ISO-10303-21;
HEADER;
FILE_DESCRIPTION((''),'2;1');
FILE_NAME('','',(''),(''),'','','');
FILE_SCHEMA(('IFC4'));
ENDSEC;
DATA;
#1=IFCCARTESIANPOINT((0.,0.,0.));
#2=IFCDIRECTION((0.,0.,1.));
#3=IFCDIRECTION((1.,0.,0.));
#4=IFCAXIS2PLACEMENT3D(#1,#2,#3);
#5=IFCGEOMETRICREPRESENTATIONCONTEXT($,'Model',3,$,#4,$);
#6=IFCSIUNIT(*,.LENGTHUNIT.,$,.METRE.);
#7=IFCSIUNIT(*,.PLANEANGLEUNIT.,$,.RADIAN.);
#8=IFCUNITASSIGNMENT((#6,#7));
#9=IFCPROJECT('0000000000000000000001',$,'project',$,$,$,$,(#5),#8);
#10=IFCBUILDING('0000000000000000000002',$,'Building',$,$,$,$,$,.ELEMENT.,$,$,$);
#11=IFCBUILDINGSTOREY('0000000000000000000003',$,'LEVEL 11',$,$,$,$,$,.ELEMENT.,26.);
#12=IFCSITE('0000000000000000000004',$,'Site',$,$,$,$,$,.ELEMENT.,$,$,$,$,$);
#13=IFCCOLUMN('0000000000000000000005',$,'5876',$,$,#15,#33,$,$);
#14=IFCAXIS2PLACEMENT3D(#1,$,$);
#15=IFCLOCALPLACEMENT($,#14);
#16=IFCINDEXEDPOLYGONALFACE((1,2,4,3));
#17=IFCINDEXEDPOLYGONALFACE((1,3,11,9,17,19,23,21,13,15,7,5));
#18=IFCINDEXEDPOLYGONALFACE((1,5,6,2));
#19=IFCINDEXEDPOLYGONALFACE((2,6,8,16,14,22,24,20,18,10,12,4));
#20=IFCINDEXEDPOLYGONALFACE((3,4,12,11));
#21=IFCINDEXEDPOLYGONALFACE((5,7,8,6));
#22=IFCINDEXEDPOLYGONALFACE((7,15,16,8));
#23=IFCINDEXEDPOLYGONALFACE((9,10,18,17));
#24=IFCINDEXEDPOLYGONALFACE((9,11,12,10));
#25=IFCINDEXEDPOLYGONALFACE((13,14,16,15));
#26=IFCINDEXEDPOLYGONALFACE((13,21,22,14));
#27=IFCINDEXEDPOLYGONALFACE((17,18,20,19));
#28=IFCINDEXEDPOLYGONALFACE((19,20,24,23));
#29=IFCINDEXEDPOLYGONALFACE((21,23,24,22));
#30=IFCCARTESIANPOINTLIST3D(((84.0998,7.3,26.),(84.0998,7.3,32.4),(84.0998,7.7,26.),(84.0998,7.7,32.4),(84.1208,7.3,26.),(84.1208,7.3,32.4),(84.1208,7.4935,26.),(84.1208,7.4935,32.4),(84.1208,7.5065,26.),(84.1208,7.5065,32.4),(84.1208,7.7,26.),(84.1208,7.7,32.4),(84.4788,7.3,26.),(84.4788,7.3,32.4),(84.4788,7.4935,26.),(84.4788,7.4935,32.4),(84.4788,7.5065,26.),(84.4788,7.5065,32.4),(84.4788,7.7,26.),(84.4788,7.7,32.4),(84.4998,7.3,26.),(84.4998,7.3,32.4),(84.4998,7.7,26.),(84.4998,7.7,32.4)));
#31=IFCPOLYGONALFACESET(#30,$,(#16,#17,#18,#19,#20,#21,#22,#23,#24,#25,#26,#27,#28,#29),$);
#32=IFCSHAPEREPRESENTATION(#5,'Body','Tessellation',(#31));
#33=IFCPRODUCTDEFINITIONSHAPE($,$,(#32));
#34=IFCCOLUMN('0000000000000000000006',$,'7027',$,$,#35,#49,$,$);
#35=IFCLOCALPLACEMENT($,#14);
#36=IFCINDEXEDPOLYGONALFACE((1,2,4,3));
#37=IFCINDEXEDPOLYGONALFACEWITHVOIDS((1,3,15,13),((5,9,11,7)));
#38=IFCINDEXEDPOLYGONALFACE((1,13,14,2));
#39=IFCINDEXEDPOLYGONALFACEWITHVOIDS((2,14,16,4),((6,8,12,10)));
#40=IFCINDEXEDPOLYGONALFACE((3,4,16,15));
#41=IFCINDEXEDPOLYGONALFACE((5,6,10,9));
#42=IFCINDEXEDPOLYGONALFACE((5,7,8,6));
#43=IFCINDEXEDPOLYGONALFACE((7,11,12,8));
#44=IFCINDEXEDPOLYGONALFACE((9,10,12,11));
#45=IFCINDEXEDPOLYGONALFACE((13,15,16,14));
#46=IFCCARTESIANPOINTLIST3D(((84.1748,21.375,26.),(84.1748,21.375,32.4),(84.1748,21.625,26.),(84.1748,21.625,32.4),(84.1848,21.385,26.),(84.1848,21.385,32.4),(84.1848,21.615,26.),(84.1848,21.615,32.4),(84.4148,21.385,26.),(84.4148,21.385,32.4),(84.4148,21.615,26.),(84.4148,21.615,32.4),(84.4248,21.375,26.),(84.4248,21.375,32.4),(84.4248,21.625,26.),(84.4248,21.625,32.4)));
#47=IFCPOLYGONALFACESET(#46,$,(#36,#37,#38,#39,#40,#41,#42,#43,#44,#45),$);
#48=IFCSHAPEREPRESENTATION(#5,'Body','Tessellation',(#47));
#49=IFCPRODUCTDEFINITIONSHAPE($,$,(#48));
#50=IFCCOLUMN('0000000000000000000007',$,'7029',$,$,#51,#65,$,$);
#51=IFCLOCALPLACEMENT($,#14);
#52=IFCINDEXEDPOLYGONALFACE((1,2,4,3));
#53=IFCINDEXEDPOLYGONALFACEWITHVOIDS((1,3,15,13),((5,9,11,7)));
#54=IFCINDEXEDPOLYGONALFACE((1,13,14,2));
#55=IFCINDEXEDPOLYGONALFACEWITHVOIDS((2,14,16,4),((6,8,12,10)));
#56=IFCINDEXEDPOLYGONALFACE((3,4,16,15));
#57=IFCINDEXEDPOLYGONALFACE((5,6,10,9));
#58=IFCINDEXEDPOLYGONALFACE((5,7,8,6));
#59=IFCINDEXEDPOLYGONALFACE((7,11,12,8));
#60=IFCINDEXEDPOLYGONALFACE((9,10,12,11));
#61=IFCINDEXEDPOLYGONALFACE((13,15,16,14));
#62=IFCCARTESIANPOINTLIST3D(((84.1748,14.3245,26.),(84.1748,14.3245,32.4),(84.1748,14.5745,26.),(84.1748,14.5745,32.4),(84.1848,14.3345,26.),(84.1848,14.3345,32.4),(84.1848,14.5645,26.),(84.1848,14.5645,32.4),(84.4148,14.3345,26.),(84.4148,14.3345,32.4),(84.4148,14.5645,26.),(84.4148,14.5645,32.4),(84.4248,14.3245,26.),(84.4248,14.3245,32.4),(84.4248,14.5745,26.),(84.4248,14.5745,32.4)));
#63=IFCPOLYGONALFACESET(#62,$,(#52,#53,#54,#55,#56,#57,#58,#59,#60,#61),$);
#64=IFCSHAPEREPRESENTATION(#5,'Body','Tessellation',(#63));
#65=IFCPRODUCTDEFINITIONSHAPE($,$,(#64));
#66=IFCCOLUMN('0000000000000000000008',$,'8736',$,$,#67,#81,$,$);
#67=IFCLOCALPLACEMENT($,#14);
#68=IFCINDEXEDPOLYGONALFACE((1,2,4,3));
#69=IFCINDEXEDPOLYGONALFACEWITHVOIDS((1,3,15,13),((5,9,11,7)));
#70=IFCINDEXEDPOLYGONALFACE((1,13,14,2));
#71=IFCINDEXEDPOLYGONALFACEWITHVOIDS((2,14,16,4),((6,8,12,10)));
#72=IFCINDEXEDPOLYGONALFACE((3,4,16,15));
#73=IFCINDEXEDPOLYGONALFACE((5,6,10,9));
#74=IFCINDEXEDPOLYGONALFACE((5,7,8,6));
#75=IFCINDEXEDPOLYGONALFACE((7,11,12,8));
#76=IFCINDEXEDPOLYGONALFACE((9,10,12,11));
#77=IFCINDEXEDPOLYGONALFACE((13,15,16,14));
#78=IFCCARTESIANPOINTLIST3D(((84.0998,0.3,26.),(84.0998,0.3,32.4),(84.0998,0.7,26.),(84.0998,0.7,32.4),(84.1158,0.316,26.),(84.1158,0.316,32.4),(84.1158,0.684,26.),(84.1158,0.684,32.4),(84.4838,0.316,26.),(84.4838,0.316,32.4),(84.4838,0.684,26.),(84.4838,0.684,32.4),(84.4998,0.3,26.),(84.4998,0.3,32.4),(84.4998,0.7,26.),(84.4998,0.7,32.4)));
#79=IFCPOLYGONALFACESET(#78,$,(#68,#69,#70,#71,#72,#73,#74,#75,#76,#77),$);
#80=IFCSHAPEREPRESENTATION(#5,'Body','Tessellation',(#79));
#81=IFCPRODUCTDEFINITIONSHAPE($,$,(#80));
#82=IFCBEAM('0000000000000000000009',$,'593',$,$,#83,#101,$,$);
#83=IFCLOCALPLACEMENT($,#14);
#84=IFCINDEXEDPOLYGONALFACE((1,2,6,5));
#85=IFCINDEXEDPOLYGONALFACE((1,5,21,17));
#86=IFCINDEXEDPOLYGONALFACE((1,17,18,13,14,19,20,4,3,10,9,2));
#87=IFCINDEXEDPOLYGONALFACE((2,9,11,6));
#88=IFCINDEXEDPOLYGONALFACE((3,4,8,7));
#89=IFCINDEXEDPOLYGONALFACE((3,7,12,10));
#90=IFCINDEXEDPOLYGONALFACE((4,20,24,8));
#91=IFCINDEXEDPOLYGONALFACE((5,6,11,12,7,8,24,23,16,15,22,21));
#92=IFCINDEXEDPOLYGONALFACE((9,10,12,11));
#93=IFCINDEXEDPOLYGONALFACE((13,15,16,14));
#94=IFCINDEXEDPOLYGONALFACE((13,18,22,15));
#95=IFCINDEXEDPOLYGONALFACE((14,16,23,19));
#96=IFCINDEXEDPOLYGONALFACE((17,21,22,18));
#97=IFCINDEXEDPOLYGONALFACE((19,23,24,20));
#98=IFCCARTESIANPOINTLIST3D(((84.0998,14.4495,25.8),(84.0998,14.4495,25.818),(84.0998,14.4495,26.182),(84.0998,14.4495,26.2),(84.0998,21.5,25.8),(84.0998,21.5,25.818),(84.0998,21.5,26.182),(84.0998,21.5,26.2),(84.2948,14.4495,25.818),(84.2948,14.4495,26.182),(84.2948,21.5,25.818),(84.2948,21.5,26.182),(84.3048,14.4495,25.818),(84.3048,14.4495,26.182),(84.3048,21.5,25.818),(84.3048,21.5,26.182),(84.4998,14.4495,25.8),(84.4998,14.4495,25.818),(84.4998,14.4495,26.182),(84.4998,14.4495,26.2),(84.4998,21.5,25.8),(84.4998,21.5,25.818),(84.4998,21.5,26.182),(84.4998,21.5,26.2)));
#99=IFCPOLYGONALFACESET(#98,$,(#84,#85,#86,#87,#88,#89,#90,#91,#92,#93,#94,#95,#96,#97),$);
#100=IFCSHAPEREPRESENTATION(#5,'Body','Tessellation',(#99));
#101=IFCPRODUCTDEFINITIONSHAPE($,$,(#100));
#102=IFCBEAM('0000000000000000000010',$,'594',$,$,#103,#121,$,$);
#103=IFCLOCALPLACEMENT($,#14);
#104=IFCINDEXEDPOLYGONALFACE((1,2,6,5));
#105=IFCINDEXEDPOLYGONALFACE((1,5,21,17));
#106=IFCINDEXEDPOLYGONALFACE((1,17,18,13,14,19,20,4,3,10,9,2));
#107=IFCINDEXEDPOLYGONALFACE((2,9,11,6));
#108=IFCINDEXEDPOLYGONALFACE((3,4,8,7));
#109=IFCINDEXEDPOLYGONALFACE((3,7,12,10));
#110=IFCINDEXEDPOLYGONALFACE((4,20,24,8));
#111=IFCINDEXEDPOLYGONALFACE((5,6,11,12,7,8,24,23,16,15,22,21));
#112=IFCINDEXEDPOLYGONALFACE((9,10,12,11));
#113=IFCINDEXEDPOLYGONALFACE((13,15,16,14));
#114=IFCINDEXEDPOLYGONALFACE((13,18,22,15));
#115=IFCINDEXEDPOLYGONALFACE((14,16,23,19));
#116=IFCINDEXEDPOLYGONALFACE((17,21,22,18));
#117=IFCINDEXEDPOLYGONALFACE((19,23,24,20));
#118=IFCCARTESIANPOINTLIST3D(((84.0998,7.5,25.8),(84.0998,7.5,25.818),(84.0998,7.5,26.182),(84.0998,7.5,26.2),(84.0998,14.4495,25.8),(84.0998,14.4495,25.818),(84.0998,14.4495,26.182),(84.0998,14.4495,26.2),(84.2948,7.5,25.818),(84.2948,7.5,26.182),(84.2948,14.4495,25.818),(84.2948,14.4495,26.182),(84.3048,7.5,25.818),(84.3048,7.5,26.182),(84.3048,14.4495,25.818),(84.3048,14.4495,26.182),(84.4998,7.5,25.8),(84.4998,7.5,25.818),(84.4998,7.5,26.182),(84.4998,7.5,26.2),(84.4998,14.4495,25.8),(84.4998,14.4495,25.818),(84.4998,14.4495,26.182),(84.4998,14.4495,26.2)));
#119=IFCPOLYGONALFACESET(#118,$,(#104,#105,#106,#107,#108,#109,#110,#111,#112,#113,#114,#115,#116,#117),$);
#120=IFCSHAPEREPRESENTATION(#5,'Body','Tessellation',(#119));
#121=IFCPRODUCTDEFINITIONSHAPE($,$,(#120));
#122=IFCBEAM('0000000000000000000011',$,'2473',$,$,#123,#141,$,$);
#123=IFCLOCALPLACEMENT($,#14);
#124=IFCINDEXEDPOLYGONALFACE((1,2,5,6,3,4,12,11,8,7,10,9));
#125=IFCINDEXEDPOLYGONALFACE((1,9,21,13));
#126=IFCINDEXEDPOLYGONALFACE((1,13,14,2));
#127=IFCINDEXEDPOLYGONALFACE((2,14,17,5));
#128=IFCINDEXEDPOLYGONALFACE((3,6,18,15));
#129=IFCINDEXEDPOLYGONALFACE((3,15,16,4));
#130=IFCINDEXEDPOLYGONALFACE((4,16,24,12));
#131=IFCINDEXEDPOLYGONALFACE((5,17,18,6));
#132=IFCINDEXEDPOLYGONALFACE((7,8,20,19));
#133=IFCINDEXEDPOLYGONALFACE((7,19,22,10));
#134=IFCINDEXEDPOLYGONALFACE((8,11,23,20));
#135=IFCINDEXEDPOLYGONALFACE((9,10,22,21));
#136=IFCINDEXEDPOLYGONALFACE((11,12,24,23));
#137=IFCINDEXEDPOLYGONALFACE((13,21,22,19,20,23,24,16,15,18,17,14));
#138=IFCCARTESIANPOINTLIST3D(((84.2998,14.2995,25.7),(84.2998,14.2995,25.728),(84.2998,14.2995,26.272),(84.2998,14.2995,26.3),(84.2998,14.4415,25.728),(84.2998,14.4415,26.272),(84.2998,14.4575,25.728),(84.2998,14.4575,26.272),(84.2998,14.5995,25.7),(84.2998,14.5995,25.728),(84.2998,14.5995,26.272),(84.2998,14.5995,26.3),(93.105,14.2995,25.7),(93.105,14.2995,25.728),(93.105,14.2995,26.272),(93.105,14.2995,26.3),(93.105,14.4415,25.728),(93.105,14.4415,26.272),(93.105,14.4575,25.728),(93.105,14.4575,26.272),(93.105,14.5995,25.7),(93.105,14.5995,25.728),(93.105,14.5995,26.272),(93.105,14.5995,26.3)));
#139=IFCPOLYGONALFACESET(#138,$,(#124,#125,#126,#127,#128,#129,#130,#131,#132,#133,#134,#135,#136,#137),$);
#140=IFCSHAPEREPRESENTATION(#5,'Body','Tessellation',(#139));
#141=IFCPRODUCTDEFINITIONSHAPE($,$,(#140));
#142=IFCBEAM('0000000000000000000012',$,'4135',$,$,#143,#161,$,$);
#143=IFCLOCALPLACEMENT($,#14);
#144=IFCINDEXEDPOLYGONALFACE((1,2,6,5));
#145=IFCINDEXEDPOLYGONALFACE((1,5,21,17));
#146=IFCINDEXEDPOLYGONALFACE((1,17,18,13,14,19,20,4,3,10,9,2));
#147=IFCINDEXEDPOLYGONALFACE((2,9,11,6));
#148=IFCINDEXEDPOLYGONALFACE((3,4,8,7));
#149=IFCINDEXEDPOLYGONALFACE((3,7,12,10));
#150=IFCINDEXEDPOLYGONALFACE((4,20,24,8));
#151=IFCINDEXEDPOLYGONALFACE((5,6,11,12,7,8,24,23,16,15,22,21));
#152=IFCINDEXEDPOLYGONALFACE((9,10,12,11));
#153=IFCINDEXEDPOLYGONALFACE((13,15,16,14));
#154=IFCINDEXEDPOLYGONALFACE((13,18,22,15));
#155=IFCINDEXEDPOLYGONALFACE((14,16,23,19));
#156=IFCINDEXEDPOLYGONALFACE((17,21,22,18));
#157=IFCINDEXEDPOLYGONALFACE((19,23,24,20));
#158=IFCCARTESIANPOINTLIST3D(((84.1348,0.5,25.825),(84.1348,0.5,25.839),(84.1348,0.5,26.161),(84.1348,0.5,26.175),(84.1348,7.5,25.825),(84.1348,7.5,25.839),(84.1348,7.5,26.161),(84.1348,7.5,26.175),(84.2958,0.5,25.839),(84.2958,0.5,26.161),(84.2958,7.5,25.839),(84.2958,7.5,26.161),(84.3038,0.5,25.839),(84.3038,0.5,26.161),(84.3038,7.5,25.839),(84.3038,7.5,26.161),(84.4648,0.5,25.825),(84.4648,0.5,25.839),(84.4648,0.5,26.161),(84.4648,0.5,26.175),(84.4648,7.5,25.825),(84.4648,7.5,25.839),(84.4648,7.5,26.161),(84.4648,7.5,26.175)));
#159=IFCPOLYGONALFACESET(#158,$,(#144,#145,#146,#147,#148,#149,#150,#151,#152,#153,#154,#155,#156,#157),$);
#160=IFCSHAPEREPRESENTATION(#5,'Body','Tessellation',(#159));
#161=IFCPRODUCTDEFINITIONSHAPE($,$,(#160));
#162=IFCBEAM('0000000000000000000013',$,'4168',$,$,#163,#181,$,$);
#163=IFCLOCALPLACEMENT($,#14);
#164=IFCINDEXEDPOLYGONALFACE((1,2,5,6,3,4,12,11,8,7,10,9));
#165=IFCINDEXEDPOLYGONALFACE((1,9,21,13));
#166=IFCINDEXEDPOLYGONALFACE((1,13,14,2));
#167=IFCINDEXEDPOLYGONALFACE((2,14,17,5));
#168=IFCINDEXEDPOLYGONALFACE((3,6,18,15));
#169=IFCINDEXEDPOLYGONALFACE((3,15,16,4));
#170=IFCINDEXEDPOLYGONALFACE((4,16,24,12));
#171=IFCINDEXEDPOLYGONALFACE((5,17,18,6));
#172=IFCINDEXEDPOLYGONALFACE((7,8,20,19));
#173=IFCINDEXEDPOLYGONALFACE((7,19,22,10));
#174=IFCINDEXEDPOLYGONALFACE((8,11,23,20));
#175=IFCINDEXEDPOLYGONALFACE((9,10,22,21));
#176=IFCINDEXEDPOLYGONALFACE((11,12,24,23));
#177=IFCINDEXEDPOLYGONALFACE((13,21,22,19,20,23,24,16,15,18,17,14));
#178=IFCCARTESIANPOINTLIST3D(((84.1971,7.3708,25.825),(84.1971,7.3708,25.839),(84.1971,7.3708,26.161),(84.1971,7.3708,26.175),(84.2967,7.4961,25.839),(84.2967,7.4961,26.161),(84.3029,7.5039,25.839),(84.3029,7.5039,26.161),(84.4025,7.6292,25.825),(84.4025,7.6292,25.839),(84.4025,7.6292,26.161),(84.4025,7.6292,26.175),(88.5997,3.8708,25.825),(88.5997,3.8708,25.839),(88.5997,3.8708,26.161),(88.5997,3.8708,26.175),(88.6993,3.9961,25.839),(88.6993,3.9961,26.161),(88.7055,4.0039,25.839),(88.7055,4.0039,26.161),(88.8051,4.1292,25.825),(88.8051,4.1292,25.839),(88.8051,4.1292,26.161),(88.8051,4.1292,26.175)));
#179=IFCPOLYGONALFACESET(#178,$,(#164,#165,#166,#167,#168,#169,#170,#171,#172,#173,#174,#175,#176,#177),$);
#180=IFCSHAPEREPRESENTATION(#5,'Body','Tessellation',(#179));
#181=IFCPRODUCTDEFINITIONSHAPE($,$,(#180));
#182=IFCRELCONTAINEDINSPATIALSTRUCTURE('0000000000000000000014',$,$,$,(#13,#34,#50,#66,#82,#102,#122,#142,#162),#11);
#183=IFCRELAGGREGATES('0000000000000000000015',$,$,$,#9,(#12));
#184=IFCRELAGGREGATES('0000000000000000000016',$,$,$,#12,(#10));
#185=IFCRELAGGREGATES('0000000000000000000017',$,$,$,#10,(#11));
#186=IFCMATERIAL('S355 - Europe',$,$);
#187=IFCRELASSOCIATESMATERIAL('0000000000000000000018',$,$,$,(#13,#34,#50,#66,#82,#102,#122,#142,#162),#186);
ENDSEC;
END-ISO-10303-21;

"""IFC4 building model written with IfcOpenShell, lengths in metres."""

from ifc_helpers import new_model, si_unit, frame, origin_with_axes, origin_2d_with_axis, place, context, project, spatial, hollow_rectangle, i_section, extrude, material, material_profile, profile_set, profile_usage, element, save


model = new_model("IFC4")

# Units and contexts
model_context = context("Model", 3, world=origin_with_axes())
ifc_project = project(units=[si_unit("LENGTHUNIT", "METRE"), si_unit("PLANEANGLEUNIT", "RADIAN")], contexts=[model_context])

# Site, building, storey
site = spatial("IfcSite", under=ifc_project, Name="Site", CompositionType="ELEMENT")
building = spatial("IfcBuilding", under=site, Name="Building", CompositionType="ELEMENT")
storey = spatial("IfcBuildingStorey", under=building, Name="LEVEL 11", CompositionType="ELEMENT", Elevation=26.0)

# Columns
ifc_material = material(Name="S355 - Europe")
ifc_material_profile_1 = material_profile(ifc_material, i_section(OverallWidth=0.4, OverallDepth=0.4, WebThickness=0.013, FlangeThickness=0.021, at=origin_2d_with_axis()))
ifc_profile_set_1 = profile_set([ifc_material_profile_1])
ifc_profile_usage_1 = profile_usage(ifc_profile_set_1, cardinal=10)
column_1_placement = place(None, frame((84.2998, 7.5, 26.0), z_axis=(0.0, 0.0, 1.0), x_axis=(0.0, -1.0, 0.0)))
element("IfcColumn", 1, at=column_1_placement, inside=storey, material=ifc_profile_usage_1, Name="5876", context=model_context, shape_type="SweptSolid", body=[
    extrude(i_section(OverallWidth=0.4, OverallDepth=0.4, WebThickness=0.013, FlangeThickness=0.021, at=origin_2d_with_axis()), origin_with_axes(), (0.0, 0.0, 1.0), 6.4),
])
ifc_material_profile_2 = material_profile(ifc_material, hollow_rectangle(XDim=0.25, YDim=0.25, WallThickness=0.01, at=origin_2d_with_axis()))
ifc_profile_set_2 = profile_set([ifc_material_profile_2])
ifc_profile_usage_2 = profile_usage(ifc_profile_set_2, cardinal=10)
column_2_placement = place(None, frame((84.2998, 21.5, 26.0), z_axis=(0.0, 0.0, 1.0), x_axis=(0.0, -1.0, 0.0)))
element("IfcColumn", 2, at=column_2_placement, inside=storey, material=ifc_profile_usage_2, Name="7027", context=model_context, shape_type="SweptSolid", body=[
    extrude(hollow_rectangle(XDim=0.25, YDim=0.25, WallThickness=0.01, at=origin_2d_with_axis()), origin_with_axes(), (0.0, 0.0, 1.0), 6.4),
])
ifc_material_profile_3 = material_profile(ifc_material, hollow_rectangle(XDim=0.25, YDim=0.25, WallThickness=0.01, at=origin_2d_with_axis()))
ifc_profile_set_3 = profile_set([ifc_material_profile_3])
ifc_profile_usage_3 = profile_usage(ifc_profile_set_3, cardinal=10)
column_3_placement = place(None, frame((84.2998, 14.4495, 26.0), z_axis=(0.0, 0.0, 1.0), x_axis=(0.0, -1.0, 0.0)))
element("IfcColumn", 3, at=column_3_placement, inside=storey, material=ifc_profile_usage_3, Name="7029", context=model_context, shape_type="SweptSolid", body=[
    extrude(hollow_rectangle(XDim=0.25, YDim=0.25, WallThickness=0.01, at=origin_2d_with_axis()), origin_with_axes(), (0.0, 0.0, 1.0), 6.4),
])
ifc_material_profile_4 = material_profile(ifc_material, hollow_rectangle(XDim=0.4, YDim=0.4, WallThickness=0.016, at=origin_2d_with_axis()))
ifc_profile_set_4 = profile_set([ifc_material_profile_4])
ifc_profile_usage_4 = profile_usage(ifc_profile_set_4, cardinal=10)
column_4_placement = place(None, frame((84.2998, 0.5, 26.0), z_axis=(0.0, 0.0, 1.0), x_axis=(0.0, -1.0, 0.0)))
element("IfcColumn", 4, at=column_4_placement, inside=storey, material=ifc_profile_usage_4, Name="8736", context=model_context, shape_type="SweptSolid", body=[
    extrude(hollow_rectangle(XDim=0.4, YDim=0.4, WallThickness=0.016, at=origin_2d_with_axis()), origin_with_axes(), (0.0, 0.0, 1.0), 6.4),
])

# Beams
ifc_material_profile_5 = material_profile(ifc_material, i_section(OverallWidth=0.4, OverallDepth=0.4, WebThickness=0.01, FlangeThickness=0.018, at=origin_2d_with_axis()))
ifc_profile_set_5 = profile_set([ifc_material_profile_5])
ifc_profile_usage_5 = profile_usage(ifc_profile_set_5, cardinal=10)
beam_1_placement = place(None, frame((84.2998, 21.5, 26.0), z_axis=(0.0, -1.0, 0.0), x_axis=(1.0, 0.0, 0.0)))
element("IfcBeam", 5, at=beam_1_placement, inside=storey, material=ifc_profile_usage_5, Name="593", context=model_context, shape_type="SweptSolid", body=[
    extrude(i_section(OverallWidth=0.4, OverallDepth=0.4, WebThickness=0.01, FlangeThickness=0.018, at=origin_2d_with_axis()), origin_with_axes(), (0.0, 0.0, 1.0), 7.0505),
])
ifc_material_profile_6 = material_profile(ifc_material, i_section(OverallWidth=0.4, OverallDepth=0.4, WebThickness=0.01, FlangeThickness=0.018, at=origin_2d_with_axis()))
ifc_profile_set_6 = profile_set([ifc_material_profile_6])
ifc_profile_usage_6 = profile_usage(ifc_profile_set_6, cardinal=10)
beam_2_placement = place(None, frame((84.2998, 14.4495, 26.0), z_axis=(0.0, -1.0, 0.0), x_axis=(1.0, 0.0, 0.0)))
element("IfcBeam", 6, at=beam_2_placement, inside=storey, material=ifc_profile_usage_6, Name="594", context=model_context, shape_type="SweptSolid", body=[
    extrude(i_section(OverallWidth=0.4, OverallDepth=0.4, WebThickness=0.01, FlangeThickness=0.018, at=origin_2d_with_axis()), origin_with_axes(), (0.0, 0.0, 1.0), 6.9495),
])
ifc_material_profile_7 = material_profile(ifc_material, i_section(OverallWidth=0.3, OverallDepth=0.6, WebThickness=0.016, FlangeThickness=0.028, at=origin_2d_with_axis()))
ifc_profile_set_7 = profile_set([ifc_material_profile_7])
ifc_profile_usage_7 = profile_usage(ifc_profile_set_7, cardinal=10)
beam_3_placement = place(None, frame((84.2998, 14.4495, 26.0), z_axis=(1.0, 0.0, 0.0), x_axis=(0.0, 1.0, 0.0)))
element("IfcBeam", 7, at=beam_3_placement, inside=storey, material=ifc_profile_usage_7, Name="2473", context=model_context, shape_type="SweptSolid", body=[
    extrude(i_section(OverallWidth=0.3, OverallDepth=0.6, WebThickness=0.016, FlangeThickness=0.028, at=origin_2d_with_axis()), origin_with_axes(), (0.0, 0.0, 1.0), 8.8052),
])
ifc_material_profile_8 = material_profile(ifc_material, i_section(OverallWidth=0.33, OverallDepth=0.35, WebThickness=0.008, FlangeThickness=0.014, at=origin_2d_with_axis()))
ifc_profile_set_8 = profile_set([ifc_material_profile_8])
ifc_profile_usage_8 = profile_usage(ifc_profile_set_8, cardinal=10)
beam_4_placement = place(None, frame((84.2998, 7.5, 26.0), z_axis=(0.0, -1.0, 0.0), x_axis=(1.0, 0.0, 0.0)))
element("IfcBeam", 8, at=beam_4_placement, inside=storey, material=ifc_profile_usage_8, Name="4135", context=model_context, shape_type="SweptSolid", body=[
    extrude(i_section(OverallWidth=0.33, OverallDepth=0.35, WebThickness=0.008, FlangeThickness=0.014, at=origin_2d_with_axis()), origin_with_axes(), (0.0, 0.0, 1.0), 7.0),
])
ifc_material_profile_9 = material_profile(ifc_material, i_section(OverallWidth=0.33, OverallDepth=0.35, WebThickness=0.01, FlangeThickness=0.014, at=origin_2d_with_axis()))
ifc_profile_set_9 = profile_set([ifc_material_profile_9])
ifc_profile_usage_9 = profile_usage(ifc_profile_set_9, cardinal=10)
beam_5_placement = place(None, frame((84.2998, 7.5, 26.0), z_axis=(0.78278, -0.622298, 0.0), x_axis=(0.622298, 0.78278, 0.0)))
element("IfcBeam", 9, at=beam_5_placement, inside=storey, material=ifc_profile_usage_9, Name="4168", context=model_context, shape_type="SweptSolid", body=[
    extrude(i_section(OverallWidth=0.33, OverallDepth=0.35, WebThickness=0.01, FlangeThickness=0.014, at=origin_2d_with_axis()), origin_with_axes(), (0.0, 0.0, 1.0), 5.6243),
])

save(model, "model.ifc")
